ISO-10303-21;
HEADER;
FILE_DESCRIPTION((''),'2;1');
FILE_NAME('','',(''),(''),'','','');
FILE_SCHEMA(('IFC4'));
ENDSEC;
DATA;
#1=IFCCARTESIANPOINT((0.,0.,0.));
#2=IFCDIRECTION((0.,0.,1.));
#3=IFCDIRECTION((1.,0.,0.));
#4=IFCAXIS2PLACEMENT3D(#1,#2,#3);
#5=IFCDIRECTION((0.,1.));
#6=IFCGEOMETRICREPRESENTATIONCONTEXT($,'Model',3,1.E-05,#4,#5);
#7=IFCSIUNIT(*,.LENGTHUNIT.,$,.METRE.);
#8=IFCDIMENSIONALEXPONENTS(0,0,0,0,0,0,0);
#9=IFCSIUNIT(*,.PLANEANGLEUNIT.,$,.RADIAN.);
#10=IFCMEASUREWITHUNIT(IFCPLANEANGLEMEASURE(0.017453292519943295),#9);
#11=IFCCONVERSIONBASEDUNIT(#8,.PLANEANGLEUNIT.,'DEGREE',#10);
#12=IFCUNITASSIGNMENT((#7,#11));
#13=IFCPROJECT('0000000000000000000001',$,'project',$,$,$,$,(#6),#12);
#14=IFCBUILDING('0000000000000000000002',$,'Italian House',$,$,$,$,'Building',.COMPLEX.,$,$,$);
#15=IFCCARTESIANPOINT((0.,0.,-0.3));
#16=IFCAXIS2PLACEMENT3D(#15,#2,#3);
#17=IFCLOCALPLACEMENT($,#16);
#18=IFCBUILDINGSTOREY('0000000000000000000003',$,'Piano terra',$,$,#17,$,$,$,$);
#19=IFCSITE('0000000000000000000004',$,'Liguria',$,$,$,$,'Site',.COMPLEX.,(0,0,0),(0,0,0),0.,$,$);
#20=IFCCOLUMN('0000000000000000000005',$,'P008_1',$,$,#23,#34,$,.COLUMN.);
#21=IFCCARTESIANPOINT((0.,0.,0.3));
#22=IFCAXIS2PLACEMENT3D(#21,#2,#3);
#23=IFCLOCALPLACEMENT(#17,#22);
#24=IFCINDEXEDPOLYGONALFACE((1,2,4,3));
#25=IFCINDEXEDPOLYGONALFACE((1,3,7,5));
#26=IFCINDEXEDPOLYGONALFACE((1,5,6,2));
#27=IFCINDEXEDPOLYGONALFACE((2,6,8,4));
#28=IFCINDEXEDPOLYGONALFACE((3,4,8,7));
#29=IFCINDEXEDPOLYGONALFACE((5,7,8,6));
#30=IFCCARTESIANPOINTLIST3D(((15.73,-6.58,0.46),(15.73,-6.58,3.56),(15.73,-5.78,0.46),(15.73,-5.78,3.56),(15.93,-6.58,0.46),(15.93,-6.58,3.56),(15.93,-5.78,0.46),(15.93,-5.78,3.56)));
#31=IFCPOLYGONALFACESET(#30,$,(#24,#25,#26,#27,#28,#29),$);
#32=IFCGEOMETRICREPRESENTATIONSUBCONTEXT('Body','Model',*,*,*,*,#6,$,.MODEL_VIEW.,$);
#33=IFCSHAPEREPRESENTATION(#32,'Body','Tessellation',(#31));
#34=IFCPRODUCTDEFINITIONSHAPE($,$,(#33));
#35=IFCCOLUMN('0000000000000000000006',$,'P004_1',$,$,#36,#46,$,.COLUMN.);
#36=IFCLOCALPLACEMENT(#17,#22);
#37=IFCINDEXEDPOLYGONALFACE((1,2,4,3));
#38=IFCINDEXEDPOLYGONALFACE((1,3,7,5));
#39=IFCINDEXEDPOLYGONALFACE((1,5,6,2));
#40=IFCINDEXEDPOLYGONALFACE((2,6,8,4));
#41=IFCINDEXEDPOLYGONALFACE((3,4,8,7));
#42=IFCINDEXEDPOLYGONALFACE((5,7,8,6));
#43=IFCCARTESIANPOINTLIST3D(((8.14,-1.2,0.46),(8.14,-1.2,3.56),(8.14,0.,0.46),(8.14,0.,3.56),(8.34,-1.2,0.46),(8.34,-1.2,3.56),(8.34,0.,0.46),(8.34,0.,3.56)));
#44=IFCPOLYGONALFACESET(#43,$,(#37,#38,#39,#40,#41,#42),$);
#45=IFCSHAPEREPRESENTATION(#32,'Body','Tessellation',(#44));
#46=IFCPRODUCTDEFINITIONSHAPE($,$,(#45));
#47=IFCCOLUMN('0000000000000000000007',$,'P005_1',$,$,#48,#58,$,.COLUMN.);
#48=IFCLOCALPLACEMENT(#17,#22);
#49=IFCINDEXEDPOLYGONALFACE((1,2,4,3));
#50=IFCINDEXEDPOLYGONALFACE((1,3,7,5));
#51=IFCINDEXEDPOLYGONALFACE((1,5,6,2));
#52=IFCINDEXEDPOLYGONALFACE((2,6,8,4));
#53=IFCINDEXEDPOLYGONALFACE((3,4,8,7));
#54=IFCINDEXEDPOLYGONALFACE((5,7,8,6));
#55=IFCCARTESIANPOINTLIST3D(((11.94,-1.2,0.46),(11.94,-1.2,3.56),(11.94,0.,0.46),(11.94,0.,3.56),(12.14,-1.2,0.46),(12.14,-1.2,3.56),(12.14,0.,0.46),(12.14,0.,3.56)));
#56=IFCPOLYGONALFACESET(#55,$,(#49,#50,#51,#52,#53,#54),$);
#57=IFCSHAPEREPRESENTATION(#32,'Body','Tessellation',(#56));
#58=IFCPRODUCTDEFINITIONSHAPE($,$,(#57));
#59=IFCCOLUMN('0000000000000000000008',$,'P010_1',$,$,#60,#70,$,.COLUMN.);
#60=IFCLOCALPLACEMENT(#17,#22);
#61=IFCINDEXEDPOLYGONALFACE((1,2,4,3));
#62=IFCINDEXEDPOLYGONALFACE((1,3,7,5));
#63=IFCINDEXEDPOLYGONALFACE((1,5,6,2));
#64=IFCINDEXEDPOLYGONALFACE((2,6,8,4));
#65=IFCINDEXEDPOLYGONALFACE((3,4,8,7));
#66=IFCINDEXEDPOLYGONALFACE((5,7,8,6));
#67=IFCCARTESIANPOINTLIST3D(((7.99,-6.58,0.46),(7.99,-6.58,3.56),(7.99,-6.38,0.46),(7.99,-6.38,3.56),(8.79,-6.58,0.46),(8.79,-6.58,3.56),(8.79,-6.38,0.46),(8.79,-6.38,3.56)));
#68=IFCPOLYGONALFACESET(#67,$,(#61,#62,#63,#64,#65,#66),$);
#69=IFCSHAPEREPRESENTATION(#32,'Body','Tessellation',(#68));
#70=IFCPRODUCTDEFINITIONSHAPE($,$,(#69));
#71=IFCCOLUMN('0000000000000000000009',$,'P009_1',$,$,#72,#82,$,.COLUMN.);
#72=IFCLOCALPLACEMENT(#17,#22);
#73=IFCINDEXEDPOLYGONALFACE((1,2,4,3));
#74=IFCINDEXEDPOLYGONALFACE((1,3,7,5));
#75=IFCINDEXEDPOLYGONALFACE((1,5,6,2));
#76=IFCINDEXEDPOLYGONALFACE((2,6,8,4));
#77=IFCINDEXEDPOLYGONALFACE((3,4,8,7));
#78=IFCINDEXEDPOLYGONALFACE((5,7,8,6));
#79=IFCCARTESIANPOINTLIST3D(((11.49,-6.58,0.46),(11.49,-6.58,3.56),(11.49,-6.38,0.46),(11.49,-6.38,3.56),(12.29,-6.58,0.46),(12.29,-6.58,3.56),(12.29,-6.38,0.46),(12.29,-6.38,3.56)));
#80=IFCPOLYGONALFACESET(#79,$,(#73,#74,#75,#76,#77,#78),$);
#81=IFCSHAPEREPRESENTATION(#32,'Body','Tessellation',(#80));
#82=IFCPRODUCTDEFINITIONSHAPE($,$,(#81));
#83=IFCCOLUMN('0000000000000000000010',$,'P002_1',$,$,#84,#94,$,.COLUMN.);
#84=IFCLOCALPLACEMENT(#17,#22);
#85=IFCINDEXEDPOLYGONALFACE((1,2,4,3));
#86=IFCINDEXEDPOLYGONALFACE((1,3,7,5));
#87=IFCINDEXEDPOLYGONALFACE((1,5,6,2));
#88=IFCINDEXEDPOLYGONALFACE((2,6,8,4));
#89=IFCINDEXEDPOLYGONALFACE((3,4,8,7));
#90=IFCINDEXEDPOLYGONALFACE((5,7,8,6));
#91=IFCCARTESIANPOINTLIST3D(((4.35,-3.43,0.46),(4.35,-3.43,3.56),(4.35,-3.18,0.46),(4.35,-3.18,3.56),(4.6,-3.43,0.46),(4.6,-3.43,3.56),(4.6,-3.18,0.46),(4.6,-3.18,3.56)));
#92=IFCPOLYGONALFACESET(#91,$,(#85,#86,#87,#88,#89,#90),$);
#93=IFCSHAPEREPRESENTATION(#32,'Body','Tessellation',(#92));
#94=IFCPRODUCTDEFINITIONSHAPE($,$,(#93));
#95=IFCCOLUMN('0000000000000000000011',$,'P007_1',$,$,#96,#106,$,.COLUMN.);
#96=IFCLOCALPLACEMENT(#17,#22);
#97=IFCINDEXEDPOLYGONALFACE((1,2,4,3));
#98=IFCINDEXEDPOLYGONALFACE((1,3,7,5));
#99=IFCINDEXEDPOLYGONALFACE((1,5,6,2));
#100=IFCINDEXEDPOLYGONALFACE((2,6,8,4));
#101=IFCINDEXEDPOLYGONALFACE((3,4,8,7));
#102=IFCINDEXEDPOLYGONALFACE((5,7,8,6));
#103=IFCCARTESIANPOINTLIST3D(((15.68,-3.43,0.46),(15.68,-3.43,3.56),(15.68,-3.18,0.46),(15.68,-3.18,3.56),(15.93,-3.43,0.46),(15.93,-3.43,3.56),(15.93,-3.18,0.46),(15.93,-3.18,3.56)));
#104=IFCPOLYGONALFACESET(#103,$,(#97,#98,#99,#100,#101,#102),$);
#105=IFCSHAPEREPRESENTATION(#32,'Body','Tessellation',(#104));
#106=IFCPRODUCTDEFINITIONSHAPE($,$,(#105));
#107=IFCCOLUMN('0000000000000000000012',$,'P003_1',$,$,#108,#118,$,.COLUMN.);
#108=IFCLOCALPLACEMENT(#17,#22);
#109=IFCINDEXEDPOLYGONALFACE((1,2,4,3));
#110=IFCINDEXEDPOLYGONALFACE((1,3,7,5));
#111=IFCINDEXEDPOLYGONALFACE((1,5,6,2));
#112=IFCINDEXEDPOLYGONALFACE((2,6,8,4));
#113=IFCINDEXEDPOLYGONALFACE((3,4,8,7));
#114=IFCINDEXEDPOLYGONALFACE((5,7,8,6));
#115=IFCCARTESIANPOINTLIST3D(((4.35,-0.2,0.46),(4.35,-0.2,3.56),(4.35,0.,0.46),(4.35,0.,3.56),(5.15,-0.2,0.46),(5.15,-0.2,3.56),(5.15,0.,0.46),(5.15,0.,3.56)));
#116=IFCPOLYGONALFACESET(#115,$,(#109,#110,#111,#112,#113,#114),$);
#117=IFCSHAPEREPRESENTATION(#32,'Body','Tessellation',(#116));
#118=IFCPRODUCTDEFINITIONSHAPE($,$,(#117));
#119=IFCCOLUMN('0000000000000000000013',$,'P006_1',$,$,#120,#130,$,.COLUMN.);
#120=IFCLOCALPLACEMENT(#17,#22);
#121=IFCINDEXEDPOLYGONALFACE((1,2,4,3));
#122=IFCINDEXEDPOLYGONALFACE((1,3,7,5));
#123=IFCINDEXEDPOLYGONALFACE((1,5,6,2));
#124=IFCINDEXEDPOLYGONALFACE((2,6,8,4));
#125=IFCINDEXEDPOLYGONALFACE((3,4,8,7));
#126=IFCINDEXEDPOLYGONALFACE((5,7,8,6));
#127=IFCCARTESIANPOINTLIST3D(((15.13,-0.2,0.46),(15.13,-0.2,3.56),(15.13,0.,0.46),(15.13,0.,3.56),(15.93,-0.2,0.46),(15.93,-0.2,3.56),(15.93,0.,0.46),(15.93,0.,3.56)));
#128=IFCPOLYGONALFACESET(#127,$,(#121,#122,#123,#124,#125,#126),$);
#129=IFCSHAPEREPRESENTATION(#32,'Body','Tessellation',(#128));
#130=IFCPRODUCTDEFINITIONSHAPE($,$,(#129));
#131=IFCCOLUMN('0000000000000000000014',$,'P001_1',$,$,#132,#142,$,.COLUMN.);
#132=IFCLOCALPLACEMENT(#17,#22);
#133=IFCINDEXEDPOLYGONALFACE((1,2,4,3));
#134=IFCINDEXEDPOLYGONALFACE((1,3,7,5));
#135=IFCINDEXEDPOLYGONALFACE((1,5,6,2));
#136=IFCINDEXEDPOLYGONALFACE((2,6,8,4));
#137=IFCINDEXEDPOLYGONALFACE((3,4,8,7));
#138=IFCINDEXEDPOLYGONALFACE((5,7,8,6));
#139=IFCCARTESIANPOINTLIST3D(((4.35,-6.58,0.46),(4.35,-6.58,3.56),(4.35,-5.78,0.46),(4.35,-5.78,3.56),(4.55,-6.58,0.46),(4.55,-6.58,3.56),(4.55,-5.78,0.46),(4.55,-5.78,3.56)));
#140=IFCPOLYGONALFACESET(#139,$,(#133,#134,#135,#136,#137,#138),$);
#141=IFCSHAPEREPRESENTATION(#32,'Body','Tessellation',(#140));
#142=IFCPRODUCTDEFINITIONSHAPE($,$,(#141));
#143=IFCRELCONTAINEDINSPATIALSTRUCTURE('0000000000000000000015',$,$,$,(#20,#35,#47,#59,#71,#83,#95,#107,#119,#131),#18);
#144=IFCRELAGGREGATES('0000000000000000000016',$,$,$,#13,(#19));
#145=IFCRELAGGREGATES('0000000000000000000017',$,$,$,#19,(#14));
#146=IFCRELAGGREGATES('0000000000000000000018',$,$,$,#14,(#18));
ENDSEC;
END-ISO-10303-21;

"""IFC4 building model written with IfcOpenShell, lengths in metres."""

from ifc_helpers import new_model, entity, si_unit, converted_unit, direction, frame, frame_2d, origin_with_axes, place, context, subcontext, project, spatial, rectangle, extrude, element, save


model = new_model("IFC4")

# Units and contexts
model_context = context("Model", 3, precision=1e-05, world=origin_with_axes(), true_north=direction((0.0, 1.0)))
body_context = subcontext(model_context, "Body", "Model", "MODEL_VIEW")
ifc_project = project(units=[si_unit("LENGTHUNIT", "METRE"), converted_unit("PLANEANGLEUNIT", "DEGREE", entity("IfcPlaneAngleMeasure", 0.017453292519943295), si_unit("PLANEANGLEUNIT", "RADIAN"), dimensions=[0, 0, 0, 0, 0, 0, 0])], contexts=[model_context])

# Site, building, storey
site = spatial("IfcSite", under=ifc_project, Name="Liguria", LongName="Site", CompositionType="COMPLEX", RefLatitude=(0, 0, 0), RefLongitude=(0, 0, 0), RefElevation=0.0)
building = spatial("IfcBuilding", under=site, Name="Italian House", LongName="Building", CompositionType="COMPLEX")
storey_placement = place(None, frame((0.0, 0.0, -0.3), z_axis=(0.0, 0.0, 1.0), x_axis=(1.0, 0.0, 0.0)))
storey = spatial("IfcBuildingStorey", under=building, at=storey_placement, Name="Piano terra")

# Columns
column_1_placement = place(storey_placement, frame((0.0, 0.0, 0.3), z_axis=(0.0, 0.0, 1.0), x_axis=(1.0, 0.0, 0.0)))
element("IfcColumn", 1, at=column_1_placement, inside=storey, Name="P008_1", PredefinedType="COLUMN", context=body_context, shape_type="SweptSolid", body=[
    extrude(rectangle(XDim=0.2, YDim=0.8, at=frame_2d((0.0, 0.0), x_axis=(1.0, 0.0))), frame((15.83, -6.18, 0.46), z_axis=(0.0, 0.0, 1.0), x_axis=(1.0, 0.0, 0.0)), (0.0, 0.0, 1.0), 3.1),
])
column_2_placement = place(storey_placement, frame((0.0, 0.0, 0.3), z_axis=(0.0, 0.0, 1.0), x_axis=(1.0, 0.0, 0.0)))
element("IfcColumn", 2, at=column_2_placement, inside=storey, Name="P004_1", PredefinedType="COLUMN", context=body_context, shape_type="SweptSolid", body=[
    extrude(rectangle(XDim=0.2, YDim=1.2, at=frame_2d((0.0, 0.0), x_axis=(1.0, 0.0))), frame((8.24, -0.6, 0.46), z_axis=(0.0, 0.0, 1.0), x_axis=(1.0, 0.0, 0.0)), (0.0, 0.0, 1.0), 3.1),
])
column_3_placement = place(storey_placement, frame((0.0, 0.0, 0.3), z_axis=(0.0, 0.0, 1.0), x_axis=(1.0, 0.0, 0.0)))
element("IfcColumn", 3, at=column_3_placement, inside=storey, Name="P005_1", PredefinedType="COLUMN", context=body_context, shape_type="SweptSolid", body=[
    extrude(rectangle(XDim=0.2, YDim=1.2, at=frame_2d((0.0, 0.0), x_axis=(1.0, 0.0))), frame((12.04, -0.6, 0.46), z_axis=(0.0, 0.0, 1.0), x_axis=(1.0, 0.0, 0.0)), (0.0, 0.0, 1.0), 3.1),
])
column_4_placement = place(storey_placement, frame((0.0, 0.0, 0.3), z_axis=(0.0, 0.0, 1.0), x_axis=(1.0, 0.0, 0.0)))
element("IfcColumn", 4, at=column_4_placement, inside=storey, Name="P010_1", PredefinedType="COLUMN", context=body_context, shape_type="SweptSolid", body=[
    extrude(rectangle(XDim=0.8, YDim=0.2, at=frame_2d((0.0, 0.0), x_axis=(1.0, 0.0))), frame((8.39, -6.48, 0.46), z_axis=(0.0, 0.0, 1.0), x_axis=(1.0, 0.0, 0.0)), (0.0, 0.0, 1.0), 3.1),
])
column_5_placement = place(storey_placement, frame((0.0, 0.0, 0.3), z_axis=(0.0, 0.0, 1.0), x_axis=(1.0, 0.0, 0.0)))
element("IfcColumn", 5, at=column_5_placement, inside=storey, Name="P009_1", PredefinedType="COLUMN", context=body_context, shape_type="SweptSolid", body=[
    extrude(rectangle(XDim=0.8, YDim=0.2, at=frame_2d((0.0, 0.0), x_axis=(1.0, 0.0))), frame((11.89, -6.48, 0.46), z_axis=(0.0, 0.0, 1.0), x_axis=(1.0, 0.0, 0.0)), (0.0, 0.0, 1.0), 3.1),
])
column_6_placement = place(storey_placement, frame((0.0, 0.0, 0.3), z_axis=(0.0, 0.0, 1.0), x_axis=(1.0, 0.0, 0.0)))
element("IfcColumn", 6, at=column_6_placement, inside=storey, Name="P002_1", PredefinedType="COLUMN", context=body_context, shape_type="SweptSolid", body=[
    extrude(rectangle(XDim=0.25, YDim=0.25, at=frame_2d((0.0, 0.0), x_axis=(1.0, 0.0))), frame((4.475, -3.305, 0.46), z_axis=(0.0, 0.0, 1.0), x_axis=(1.0, 0.0, 0.0)), (0.0, 0.0, 1.0), 3.1),
])
column_7_placement = place(storey_placement, frame((0.0, 0.0, 0.3), z_axis=(0.0, 0.0, 1.0), x_axis=(1.0, 0.0, 0.0)))
element("IfcColumn", 7, at=column_7_placement, inside=storey, Name="P007_1", PredefinedType="COLUMN", context=body_context, shape_type="SweptSolid", body=[
    extrude(rectangle(XDim=0.25, YDim=0.25, at=frame_2d((0.0, 0.0), x_axis=(1.0, 0.0))), frame((15.805, -3.305, 0.46), z_axis=(0.0, 0.0, 1.0), x_axis=(1.0, 0.0, 0.0)), (0.0, 0.0, 1.0), 3.1),
])
column_8_placement = place(storey_placement, frame((0.0, 0.0, 0.3), z_axis=(0.0, 0.0, 1.0), x_axis=(1.0, 0.0, 0.0)))
element("IfcColumn", 8, at=column_8_placement, inside=storey, Name="P003_1", PredefinedType="COLUMN", context=body_context, shape_type="SweptSolid", body=[
    extrude(rectangle(XDim=0.8, YDim=0.2, at=frame_2d((0.0, 0.0), x_axis=(1.0, 0.0))), frame((4.75, -0.1, 0.46), z_axis=(0.0, 0.0, 1.0), x_axis=(1.0, 0.0, 0.0)), (0.0, 0.0, 1.0), 3.1),
])
column_9_placement = place(storey_placement, frame((0.0, 0.0, 0.3), z_axis=(0.0, 0.0, 1.0), x_axis=(1.0, 0.0, 0.0)))
element("IfcColumn", 9, at=column_9_placement, inside=storey, Name="P006_1", PredefinedType="COLUMN", context=body_context, shape_type="SweptSolid", body=[
    extrude(rectangle(XDim=0.8, YDim=0.2, at=frame_2d((0.0, 0.0), x_axis=(1.0, 0.0))), frame((15.53, -0.1, 0.46), z_axis=(0.0, 0.0, 1.0), x_axis=(1.0, 0.0, 0.0)), (0.0, 0.0, 1.0), 3.1),
])
column_10_placement = place(storey_placement, frame((0.0, 0.0, 0.3), z_axis=(0.0, 0.0, 1.0), x_axis=(1.0, 0.0, 0.0)))
element("IfcColumn", 10, at=column_10_placement, inside=storey, Name="P001_1", PredefinedType="COLUMN", context=body_context, shape_type="SweptSolid", body=[
    extrude(rectangle(XDim=0.2, YDim=0.8, at=frame_2d((0.0, 0.0), x_axis=(1.0, 0.0))), frame((4.45, -6.18, 0.46), z_axis=(0.0, 0.0, 1.0), x_axis=(1.0, 0.0, 0.0)), (0.0, 0.0, 1.0), 3.1),
])

save(model, "model.ifc")
